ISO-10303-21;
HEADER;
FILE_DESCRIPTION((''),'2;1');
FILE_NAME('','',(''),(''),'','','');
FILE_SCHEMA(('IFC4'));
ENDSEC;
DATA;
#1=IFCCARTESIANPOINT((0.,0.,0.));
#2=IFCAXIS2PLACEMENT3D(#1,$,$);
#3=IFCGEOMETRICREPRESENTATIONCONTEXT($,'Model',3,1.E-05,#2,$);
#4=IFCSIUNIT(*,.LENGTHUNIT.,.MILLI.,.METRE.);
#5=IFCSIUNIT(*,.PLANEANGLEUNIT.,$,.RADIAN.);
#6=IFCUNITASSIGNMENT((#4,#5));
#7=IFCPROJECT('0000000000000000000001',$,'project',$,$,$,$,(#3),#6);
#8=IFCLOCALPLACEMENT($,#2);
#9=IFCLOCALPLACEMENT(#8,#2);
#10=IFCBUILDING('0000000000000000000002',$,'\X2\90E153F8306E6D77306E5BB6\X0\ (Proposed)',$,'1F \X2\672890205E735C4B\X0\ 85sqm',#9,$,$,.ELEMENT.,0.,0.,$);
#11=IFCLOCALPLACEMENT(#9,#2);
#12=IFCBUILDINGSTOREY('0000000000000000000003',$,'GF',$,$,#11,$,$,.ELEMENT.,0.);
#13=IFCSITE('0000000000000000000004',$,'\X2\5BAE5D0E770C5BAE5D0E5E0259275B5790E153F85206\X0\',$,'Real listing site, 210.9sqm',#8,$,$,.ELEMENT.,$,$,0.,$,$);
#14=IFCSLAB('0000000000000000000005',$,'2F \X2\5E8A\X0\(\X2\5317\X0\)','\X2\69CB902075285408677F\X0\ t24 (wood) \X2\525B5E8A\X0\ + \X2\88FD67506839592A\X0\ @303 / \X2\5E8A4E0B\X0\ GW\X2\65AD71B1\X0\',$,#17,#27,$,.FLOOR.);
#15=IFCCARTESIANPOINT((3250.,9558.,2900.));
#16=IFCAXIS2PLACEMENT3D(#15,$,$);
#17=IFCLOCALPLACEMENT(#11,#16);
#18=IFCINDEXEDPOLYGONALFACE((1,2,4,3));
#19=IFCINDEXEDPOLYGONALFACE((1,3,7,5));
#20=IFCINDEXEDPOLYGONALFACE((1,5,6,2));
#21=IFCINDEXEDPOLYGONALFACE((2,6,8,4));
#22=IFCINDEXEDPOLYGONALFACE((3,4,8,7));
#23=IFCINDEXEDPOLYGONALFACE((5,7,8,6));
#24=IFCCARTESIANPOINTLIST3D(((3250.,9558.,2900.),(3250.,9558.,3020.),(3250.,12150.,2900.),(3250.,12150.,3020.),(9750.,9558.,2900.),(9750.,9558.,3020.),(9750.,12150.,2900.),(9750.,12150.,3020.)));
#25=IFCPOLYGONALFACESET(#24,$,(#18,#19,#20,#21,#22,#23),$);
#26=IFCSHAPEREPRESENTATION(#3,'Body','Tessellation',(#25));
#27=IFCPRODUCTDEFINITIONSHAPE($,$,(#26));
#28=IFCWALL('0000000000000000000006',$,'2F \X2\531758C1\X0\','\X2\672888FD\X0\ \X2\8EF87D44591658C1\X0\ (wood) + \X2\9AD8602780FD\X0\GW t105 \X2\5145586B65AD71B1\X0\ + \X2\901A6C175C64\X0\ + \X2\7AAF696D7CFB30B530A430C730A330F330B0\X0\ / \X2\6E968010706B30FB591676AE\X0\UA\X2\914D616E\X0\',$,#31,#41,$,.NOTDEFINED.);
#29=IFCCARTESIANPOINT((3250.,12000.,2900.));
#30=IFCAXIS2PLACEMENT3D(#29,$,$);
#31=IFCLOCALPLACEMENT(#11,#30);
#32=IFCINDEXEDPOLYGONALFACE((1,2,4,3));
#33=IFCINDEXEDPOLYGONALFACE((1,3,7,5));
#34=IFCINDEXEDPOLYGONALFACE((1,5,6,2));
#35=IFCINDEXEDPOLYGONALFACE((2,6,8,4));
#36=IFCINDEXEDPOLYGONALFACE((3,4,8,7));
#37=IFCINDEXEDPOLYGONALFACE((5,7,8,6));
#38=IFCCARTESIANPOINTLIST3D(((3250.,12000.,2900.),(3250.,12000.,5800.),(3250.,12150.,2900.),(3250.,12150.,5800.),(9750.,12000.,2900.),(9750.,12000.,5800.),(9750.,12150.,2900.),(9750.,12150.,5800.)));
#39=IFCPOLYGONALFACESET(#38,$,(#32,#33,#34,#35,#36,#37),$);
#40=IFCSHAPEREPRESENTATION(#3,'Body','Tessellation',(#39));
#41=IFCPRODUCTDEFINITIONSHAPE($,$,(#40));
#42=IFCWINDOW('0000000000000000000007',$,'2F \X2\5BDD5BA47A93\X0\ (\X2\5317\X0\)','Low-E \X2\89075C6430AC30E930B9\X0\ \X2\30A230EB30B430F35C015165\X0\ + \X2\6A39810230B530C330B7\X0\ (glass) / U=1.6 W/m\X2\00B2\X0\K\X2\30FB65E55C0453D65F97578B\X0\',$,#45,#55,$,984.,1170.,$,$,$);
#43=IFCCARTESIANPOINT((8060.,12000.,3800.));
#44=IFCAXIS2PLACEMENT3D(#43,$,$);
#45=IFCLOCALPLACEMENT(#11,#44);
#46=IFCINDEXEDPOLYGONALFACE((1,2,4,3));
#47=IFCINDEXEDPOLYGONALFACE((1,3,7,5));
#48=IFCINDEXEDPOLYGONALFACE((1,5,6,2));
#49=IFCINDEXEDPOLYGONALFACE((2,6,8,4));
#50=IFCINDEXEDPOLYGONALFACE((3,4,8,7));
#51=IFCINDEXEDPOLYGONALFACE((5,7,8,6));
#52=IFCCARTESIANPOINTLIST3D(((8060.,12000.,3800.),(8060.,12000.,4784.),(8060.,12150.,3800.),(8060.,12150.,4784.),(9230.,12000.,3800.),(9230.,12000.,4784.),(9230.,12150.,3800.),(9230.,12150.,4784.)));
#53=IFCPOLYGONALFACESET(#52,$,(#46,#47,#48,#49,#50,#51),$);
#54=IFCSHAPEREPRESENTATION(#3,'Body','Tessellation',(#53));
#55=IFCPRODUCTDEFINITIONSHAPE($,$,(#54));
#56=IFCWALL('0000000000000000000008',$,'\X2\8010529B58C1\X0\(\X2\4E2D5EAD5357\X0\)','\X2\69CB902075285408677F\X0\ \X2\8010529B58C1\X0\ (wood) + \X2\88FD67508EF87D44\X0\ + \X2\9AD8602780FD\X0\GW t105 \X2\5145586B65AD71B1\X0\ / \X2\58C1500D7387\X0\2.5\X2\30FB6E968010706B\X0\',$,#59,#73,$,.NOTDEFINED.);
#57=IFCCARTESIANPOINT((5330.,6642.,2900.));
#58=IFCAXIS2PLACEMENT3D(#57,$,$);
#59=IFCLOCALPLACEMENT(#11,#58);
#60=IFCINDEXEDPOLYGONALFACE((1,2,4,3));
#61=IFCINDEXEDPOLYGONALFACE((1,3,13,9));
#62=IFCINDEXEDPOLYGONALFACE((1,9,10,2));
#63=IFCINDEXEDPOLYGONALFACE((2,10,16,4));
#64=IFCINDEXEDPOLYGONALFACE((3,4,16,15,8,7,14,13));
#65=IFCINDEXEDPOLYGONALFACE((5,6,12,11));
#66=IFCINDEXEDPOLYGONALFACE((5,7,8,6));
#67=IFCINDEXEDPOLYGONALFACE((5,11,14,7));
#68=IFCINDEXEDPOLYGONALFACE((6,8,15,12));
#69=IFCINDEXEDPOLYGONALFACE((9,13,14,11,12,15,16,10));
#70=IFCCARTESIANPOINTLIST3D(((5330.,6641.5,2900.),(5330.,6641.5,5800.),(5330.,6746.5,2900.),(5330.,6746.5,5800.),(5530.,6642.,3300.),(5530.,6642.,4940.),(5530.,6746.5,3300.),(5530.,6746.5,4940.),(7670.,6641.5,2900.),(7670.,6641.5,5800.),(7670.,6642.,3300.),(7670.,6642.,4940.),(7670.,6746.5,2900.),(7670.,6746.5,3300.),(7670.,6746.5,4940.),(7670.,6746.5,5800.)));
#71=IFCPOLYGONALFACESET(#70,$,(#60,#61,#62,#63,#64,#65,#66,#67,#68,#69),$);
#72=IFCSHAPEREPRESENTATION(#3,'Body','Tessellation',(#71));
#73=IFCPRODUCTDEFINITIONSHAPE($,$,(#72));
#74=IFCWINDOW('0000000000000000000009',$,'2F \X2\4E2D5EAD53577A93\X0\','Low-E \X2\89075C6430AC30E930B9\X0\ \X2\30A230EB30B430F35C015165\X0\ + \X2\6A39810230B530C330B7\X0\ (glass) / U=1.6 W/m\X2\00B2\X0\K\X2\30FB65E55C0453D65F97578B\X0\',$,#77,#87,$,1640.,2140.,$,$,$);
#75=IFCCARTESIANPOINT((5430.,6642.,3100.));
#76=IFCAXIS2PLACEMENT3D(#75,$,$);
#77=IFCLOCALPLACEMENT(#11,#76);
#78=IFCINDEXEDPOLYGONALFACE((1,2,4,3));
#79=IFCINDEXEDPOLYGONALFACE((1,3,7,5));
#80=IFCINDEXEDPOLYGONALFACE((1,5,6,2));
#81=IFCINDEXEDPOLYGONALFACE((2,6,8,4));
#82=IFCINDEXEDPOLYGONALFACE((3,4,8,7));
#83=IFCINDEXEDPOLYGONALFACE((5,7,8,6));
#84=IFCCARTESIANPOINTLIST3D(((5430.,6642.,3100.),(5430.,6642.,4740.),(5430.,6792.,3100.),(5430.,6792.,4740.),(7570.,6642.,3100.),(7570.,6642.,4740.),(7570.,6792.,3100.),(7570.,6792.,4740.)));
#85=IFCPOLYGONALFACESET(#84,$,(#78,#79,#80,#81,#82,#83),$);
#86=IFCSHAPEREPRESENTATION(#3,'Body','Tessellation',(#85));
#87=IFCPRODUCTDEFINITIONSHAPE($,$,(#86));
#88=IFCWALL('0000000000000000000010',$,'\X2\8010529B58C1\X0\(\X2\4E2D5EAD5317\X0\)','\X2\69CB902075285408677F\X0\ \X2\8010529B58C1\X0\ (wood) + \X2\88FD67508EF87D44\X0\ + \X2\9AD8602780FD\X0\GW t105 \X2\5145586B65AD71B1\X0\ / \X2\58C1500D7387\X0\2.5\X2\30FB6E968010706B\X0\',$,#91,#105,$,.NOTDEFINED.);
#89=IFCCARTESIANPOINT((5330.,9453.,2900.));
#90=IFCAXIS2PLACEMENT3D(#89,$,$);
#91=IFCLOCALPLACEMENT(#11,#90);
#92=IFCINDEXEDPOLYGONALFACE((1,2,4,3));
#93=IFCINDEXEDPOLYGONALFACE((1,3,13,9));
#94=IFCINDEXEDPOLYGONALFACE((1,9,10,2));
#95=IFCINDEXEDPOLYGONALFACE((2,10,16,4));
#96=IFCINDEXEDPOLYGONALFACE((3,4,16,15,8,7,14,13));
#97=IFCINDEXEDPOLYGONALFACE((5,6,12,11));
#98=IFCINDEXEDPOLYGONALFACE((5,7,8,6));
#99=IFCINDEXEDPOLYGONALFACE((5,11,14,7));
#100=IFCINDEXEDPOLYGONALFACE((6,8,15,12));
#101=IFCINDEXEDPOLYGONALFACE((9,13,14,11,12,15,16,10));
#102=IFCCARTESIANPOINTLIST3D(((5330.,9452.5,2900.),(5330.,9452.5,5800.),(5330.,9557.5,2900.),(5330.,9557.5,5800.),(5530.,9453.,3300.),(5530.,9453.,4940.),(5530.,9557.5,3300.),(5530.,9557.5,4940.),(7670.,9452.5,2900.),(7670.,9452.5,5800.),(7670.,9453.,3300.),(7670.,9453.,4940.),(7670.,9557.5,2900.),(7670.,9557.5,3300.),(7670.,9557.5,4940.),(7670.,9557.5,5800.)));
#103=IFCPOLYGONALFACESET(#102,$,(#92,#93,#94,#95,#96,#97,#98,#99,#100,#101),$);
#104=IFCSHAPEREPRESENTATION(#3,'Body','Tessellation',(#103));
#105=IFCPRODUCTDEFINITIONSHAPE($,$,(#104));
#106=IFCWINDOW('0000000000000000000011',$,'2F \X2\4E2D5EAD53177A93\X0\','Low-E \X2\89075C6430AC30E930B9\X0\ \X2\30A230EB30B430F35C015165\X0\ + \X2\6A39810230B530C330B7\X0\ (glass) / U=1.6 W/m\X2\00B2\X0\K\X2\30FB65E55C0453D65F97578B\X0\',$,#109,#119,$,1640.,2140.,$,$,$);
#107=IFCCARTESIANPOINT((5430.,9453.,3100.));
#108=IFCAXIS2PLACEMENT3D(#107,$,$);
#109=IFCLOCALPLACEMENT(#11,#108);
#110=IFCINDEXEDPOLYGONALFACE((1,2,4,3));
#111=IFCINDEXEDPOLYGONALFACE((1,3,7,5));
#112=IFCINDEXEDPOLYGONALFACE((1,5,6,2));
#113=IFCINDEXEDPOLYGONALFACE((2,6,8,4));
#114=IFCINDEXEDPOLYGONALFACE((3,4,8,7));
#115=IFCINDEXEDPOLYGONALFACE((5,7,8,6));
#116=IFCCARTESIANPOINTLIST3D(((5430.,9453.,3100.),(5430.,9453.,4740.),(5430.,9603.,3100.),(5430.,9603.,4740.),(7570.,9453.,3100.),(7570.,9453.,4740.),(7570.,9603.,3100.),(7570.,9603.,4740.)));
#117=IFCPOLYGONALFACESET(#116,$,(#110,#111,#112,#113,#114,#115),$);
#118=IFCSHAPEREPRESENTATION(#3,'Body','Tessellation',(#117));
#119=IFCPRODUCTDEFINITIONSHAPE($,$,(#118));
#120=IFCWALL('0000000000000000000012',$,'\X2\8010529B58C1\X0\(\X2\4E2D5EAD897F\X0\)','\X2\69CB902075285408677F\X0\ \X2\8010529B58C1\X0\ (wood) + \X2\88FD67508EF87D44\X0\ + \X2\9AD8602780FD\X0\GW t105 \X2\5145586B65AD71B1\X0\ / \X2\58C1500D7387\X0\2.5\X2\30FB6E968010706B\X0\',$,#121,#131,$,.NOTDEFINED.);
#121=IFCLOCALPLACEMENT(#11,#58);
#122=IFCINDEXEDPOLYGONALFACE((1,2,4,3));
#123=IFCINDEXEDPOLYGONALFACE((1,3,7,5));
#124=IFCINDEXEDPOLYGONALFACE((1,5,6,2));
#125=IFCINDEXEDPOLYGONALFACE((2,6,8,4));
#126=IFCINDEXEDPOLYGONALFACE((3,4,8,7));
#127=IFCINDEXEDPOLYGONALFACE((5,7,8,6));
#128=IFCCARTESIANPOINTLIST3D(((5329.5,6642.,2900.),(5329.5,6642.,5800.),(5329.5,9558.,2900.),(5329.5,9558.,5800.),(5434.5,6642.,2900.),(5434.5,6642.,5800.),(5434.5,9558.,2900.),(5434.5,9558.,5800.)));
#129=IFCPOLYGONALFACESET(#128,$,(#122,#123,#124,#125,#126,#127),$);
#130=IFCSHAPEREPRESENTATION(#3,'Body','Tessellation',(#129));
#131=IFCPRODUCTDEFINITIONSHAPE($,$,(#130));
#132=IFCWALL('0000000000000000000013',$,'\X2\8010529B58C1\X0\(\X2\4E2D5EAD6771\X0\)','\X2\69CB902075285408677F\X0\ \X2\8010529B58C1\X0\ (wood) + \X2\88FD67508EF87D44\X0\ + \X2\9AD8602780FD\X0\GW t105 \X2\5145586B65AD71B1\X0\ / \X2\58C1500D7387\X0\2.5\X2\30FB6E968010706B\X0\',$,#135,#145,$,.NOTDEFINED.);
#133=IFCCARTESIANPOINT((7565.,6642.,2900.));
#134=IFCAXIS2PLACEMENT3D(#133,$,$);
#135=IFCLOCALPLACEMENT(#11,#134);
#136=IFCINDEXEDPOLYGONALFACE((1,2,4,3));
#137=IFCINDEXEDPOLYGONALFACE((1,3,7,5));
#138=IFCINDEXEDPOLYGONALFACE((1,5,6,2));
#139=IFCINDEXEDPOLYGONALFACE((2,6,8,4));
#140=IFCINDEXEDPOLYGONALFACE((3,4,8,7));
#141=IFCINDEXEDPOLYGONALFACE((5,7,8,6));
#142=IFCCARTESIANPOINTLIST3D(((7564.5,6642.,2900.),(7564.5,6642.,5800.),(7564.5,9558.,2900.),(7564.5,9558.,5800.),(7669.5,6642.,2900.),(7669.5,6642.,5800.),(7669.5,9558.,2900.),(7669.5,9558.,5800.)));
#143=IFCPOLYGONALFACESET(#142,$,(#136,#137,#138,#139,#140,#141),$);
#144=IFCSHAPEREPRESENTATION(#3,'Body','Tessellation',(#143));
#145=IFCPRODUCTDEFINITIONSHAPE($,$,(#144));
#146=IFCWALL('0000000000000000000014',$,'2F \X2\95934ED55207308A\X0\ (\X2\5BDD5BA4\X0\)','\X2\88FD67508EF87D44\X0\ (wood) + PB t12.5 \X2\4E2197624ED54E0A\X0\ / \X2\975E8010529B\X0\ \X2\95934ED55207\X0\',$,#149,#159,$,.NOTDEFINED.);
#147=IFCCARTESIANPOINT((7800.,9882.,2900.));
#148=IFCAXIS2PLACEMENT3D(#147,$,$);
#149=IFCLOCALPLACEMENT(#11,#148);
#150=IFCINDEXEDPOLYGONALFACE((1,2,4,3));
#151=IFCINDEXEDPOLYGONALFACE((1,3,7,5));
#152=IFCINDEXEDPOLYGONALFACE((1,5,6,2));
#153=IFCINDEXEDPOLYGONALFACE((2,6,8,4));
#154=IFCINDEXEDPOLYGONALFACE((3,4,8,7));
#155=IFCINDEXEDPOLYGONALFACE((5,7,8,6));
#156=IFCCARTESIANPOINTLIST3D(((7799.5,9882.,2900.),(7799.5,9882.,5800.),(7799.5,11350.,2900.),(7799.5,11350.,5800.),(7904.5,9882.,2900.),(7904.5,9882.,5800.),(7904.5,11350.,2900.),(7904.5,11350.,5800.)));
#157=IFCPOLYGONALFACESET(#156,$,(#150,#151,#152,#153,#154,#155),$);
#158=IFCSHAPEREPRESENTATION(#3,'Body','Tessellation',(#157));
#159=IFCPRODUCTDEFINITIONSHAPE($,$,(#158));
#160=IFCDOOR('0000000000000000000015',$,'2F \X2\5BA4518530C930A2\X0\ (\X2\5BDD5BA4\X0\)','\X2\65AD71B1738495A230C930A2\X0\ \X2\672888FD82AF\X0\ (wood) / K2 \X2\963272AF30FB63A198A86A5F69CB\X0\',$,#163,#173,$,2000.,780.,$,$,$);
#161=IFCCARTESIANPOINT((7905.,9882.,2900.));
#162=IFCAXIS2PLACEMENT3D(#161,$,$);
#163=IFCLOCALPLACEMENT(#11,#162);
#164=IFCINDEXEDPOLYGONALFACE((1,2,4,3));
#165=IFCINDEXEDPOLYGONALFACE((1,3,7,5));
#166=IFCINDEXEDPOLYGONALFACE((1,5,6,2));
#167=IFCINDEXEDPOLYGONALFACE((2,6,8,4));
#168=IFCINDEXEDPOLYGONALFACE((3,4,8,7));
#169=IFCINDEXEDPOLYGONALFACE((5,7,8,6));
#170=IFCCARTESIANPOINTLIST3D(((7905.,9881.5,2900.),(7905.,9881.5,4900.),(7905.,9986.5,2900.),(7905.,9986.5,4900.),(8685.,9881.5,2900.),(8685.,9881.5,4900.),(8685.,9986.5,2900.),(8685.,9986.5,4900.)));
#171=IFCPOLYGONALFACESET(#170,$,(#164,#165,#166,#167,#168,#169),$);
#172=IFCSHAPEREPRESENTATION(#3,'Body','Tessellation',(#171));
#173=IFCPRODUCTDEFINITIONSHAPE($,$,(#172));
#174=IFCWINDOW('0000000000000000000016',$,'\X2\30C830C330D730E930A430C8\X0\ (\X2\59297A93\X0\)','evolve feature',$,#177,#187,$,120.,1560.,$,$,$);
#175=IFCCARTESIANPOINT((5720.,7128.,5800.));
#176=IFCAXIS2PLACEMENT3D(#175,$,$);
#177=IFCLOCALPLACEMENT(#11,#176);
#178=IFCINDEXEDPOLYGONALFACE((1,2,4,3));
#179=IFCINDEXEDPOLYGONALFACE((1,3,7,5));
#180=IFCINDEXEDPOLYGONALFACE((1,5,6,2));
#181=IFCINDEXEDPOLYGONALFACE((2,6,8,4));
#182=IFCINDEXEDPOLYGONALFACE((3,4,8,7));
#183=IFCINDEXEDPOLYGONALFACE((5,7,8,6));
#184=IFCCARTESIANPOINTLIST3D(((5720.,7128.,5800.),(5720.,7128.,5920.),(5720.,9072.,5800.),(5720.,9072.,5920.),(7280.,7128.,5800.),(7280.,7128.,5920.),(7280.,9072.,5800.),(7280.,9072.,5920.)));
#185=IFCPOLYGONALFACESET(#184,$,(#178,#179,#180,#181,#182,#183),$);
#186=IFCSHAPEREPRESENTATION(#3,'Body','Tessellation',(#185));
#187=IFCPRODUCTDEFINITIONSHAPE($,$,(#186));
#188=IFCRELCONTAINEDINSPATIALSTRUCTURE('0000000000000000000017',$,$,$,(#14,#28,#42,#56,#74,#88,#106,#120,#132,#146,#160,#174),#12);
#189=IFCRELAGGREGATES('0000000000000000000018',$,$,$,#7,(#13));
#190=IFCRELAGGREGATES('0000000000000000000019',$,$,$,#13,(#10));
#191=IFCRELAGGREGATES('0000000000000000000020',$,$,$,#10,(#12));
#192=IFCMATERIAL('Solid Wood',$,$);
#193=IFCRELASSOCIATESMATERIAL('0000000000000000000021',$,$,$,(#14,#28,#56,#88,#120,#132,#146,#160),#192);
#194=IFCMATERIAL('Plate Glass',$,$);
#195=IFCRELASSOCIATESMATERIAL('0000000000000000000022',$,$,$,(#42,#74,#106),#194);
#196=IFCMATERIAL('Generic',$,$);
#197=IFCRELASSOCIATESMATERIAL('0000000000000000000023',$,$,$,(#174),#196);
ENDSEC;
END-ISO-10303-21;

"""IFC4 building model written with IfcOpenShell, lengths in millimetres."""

from ifc_helpers import new_model, si_unit, frame, frame_2d, origin, place, context, project, spatial, rectangle, extrude, material, element, fill, save


model = new_model("IFC4")

# Units and contexts
model_context = context("Model", 3, precision=1e-05, world=origin())
ifc_project = project(units=[si_unit("LENGTHUNIT", "METRE", prefix="MILLI"), si_unit("PLANEANGLEUNIT", "RADIAN")], contexts=[model_context])

# Site, building, storey
site_placement = place(None, origin())
site = spatial("IfcSite", under=ifc_project, at=site_placement, Name="宮崎県宮崎市大字郡司分", ObjectType="Real listing site, 210.9sqm", CompositionType="ELEMENT", RefElevation=0.0)
building_placement = place(site_placement, origin())
building = spatial("IfcBuilding", under=site, at=building_placement, Name="郡司の海の家 (Proposed)", ObjectType="1F 木造平屋 85sqm", CompositionType="ELEMENT", ElevationOfRefHeight=0.0, ElevationOfTerrain=0.0)
storey_placement = place(building_placement, origin())
storey = spatial("IfcBuildingStorey", under=building, at=storey_placement, Name="GF", CompositionType="ELEMENT", Elevation=0.0)

# Slab
ifc_material_1 = material(Name="Solid Wood")
slab_placement = place(storey_placement, frame((3250.0, 9558.0, 2900.0)))
element("IfcSlab", 1, at=slab_placement, inside=storey, material=ifc_material_1, Name="2F 床(北)", Description="構造用合板 t24 (wood) 剛床 + 製材根太 @303 / 床下 GW断熱", PredefinedType="FLOOR", context=model_context, shape_type="SweptSolid", body=[
    extrude(rectangle(XDim=6500.0, YDim=2592.0, at=frame_2d((3250.0, 1296.0))), frame((3250.0, 9558.0, 2900.0)), (0.0, 0.0, 1.0), 120.0),
])

# Walls, openings, windows
wall_1_placement = place(storey_placement, frame((3250.0, 12000.0, 2900.0)))
wall_1 = element("IfcWall", 2, at=wall_1_placement, inside=storey, material=ifc_material_1, Name="2F 北壁", Description="木製 軸組外壁 (wood) + 高性能GW t105 充填断熱 + 通気層 + 窯業系サイディング / 準耐火・外皮UA配慮", PredefinedType="NOTDEFINED", context=model_context, shape_type="SweptSolid", body=[
    extrude(rectangle(XDim=6500.0, YDim=150.0, at=frame_2d((3250.0, 75.0))), frame((3250.0, 12000.0, 2900.0)), (0.0, 0.0, 1.0), 2900.0),
])
opening_1_placement = place(storey_placement, frame((8060.0, 12000.0, 3800.0)))
opening_1 = element("IfcOpeningElement", 3, at=opening_1_placement, cuts=wall_1, PredefinedType="NOTDEFINED", context=model_context, shape_type="SweptSolid", body=[
    extrude(rectangle(XDim=1170.0, YDim=150.0, at=frame_2d((585.0, 75.0))), frame((8060.0, 12000.0, 3800.0)), (0.0, 0.0, 1.0), 984.0),
])
ifc_material_2 = material(Name="Plate Glass")
window_1_placement = place(storey_placement, frame((8060.0, 12000.0, 3800.0)))
window_1 = element("IfcWindow", 4, at=window_1_placement, inside=storey, material=ifc_material_2, Name="2F 寝室窓 (北)", Description="Low-E 複層ガラス アルゴン封入 + 樹脂サッシ (glass) / U=1.6 W/m²K・日射取得型", OverallHeight=984.0, OverallWidth=1170.0, context=model_context, shape_type="SweptSolid", body=[
    extrude(rectangle(XDim=1170.0, YDim=150.0, at=frame_2d((585.0, 75.0))), frame((8060.0, 12000.0, 3800.0)), (0.0, 0.0, 1.0), 984.0),
])
fill(opening_1, window_1)
wall_2_placement = place(storey_placement, frame((5330.0, 6642.0, 2900.0)))
wall_2 = element("IfcWall", 5, at=wall_2_placement, inside=storey, material=ifc_material_1, Name="耐力壁(中庭南)", Description="構造用合板 耐力壁 (wood) + 製材軸組 + 高性能GW t105 充填断熱 / 壁倍率2.5・準耐火", PredefinedType="NOTDEFINED", context=model_context, shape_type="SweptSolid", body=[
    extrude(rectangle(XDim=2340.0, YDim=105.0, at=frame_2d((1170.0, 52.0))), frame((5330.0, 6642.0, 2900.0)), (0.0, 0.0, 1.0), 2900.0),
])
opening_2_placement = place(storey_placement, frame((5430.0, 6642.0, 3100.0)))
opening_2 = element("IfcOpeningElement", 6, at=opening_2_placement, cuts=wall_2, PredefinedType="NOTDEFINED", context=model_context, shape_type="SweptSolid", body=[
    extrude(rectangle(XDim=2140.0, YDim=150.0, at=frame_2d((1070.0, 75.0))), frame((5430.0, 6642.0, 3100.0)), (0.0, 0.0, 1.0), 1640.0),
])
window_2_placement = place(storey_placement, frame((5430.0, 6642.0, 3100.0)))
window_2 = element("IfcWindow", 7, at=window_2_placement, inside=storey, material=ifc_material_2, Name="2F 中庭南窓", Description="Low-E 複層ガラス アルゴン封入 + 樹脂サッシ (glass) / U=1.6 W/m²K・日射取得型", OverallHeight=1640.0, OverallWidth=2140.0, context=model_context, shape_type="SweptSolid", body=[
    extrude(rectangle(XDim=2140.0, YDim=150.0, at=frame_2d((1070.0, 75.0))), frame((5430.0, 6642.0, 3100.0)), (0.0, 0.0, 1.0), 1640.0),
])
fill(opening_2, window_2)
wall_3_placement = place(storey_placement, frame((5330.0, 9453.0, 2900.0)))
wall_3 = element("IfcWall", 8, at=wall_3_placement, inside=storey, material=ifc_material_1, Name="耐力壁(中庭北)", Description="構造用合板 耐力壁 (wood) + 製材軸組 + 高性能GW t105 充填断熱 / 壁倍率2.5・準耐火", PredefinedType="NOTDEFINED", context=model_context, shape_type="SweptSolid", body=[
    extrude(rectangle(XDim=2340.0, YDim=105.0, at=frame_2d((1170.0, 52.0))), frame((5330.0, 9453.0, 2900.0)), (0.0, 0.0, 1.0), 2900.0),
])
opening_3_placement = place(storey_placement, frame((5430.0, 9453.0, 3100.0)))
opening_3 = element("IfcOpeningElement", 9, at=opening_3_placement, cuts=wall_3, PredefinedType="NOTDEFINED", context=model_context, shape_type="SweptSolid", body=[
    extrude(rectangle(XDim=2140.0, YDim=150.0, at=frame_2d((1070.0, 75.0))), frame((5430.0, 9453.0, 3100.0)), (0.0, 0.0, 1.0), 1640.0),
])
window_3_placement = place(storey_placement, frame((5430.0, 9453.0, 3100.0)))
window_3 = element("IfcWindow", 10, at=window_3_placement, inside=storey, material=ifc_material_2, Name="2F 中庭北窓", Description="Low-E 複層ガラス アルゴン封入 + 樹脂サッシ (glass) / U=1.6 W/m²K・日射取得型", OverallHeight=1640.0, OverallWidth=2140.0, context=model_context, shape_type="SweptSolid", body=[
    extrude(rectangle(XDim=2140.0, YDim=150.0, at=frame_2d((1070.0, 75.0))), frame((5430.0, 9453.0, 3100.0)), (0.0, 0.0, 1.0), 1640.0),
])
fill(opening_3, window_3)

# Walls
wall_4_placement = place(storey_placement, frame((5330.0, 6642.0, 2900.0)))
element("IfcWall", 11, at=wall_4_placement, inside=storey, material=ifc_material_1, Name="耐力壁(中庭西)", Description="構造用合板 耐力壁 (wood) + 製材軸組 + 高性能GW t105 充填断熱 / 壁倍率2.5・準耐火", PredefinedType="NOTDEFINED", context=model_context, shape_type="SweptSolid", body=[
    extrude(rectangle(XDim=105.0, YDim=2916.0, at=frame_2d((52.0, 1458.0))), frame((5330.0, 6642.0, 2900.0)), (0.0, 0.0, 1.0), 2900.0),
])
wall_5_placement = place(storey_placement, frame((7565.0, 6642.0, 2900.0)))
element("IfcWall", 12, at=wall_5_placement, inside=storey, material=ifc_material_1, Name="耐力壁(中庭東)", Description="構造用合板 耐力壁 (wood) + 製材軸組 + 高性能GW t105 充填断熱 / 壁倍率2.5・準耐火", PredefinedType="NOTDEFINED", context=model_context, shape_type="SweptSolid", body=[
    extrude(rectangle(XDim=105.0, YDim=2916.0, at=frame_2d((52.0, 1458.0))), frame((7565.0, 6642.0, 2900.0)), (0.0, 0.0, 1.0), 2900.0),
])
wall_6_placement = place(storey_placement, frame((7800.0, 9882.0, 2900.0)))
element("IfcWall", 13, at=wall_6_placement, inside=storey, material=ifc_material_1, Name="2F 間仕切り (寝室)", Description="製材軸組 (wood) + PB t12.5 両面仕上 / 非耐力 間仕切", PredefinedType="NOTDEFINED", context=model_context, shape_type="SweptSolid", body=[
    extrude(rectangle(XDim=105.0, YDim=1468.0, at=frame_2d((52.0, 734.0))), frame((7800.0, 9882.0, 2900.0)), (0.0, 0.0, 1.0), 2900.0),
])

# Door
door_placement = place(storey_placement, frame((7905.0, 9882.0, 2900.0)))
element("IfcDoor", 14, at=door_placement, inside=storey, material=ifc_material_1, Name="2F 室内ドア (寝室)", Description="断熱玄関ドア 木製芯 (wood) / K2 防犯・採風機構", OverallHeight=2000.0, OverallWidth=780.0, context=model_context, shape_type="SweptSolid", body=[
    extrude(rectangle(XDim=780.0, YDim=105.0, at=frame_2d((390.0, 52.0))), frame((7905.0, 9882.0, 2900.0)), (0.0, 0.0, 1.0), 2000.0),
])

# Window
ifc_material_3 = material(Name="Generic")
window_4_placement = place(storey_placement, frame((5720.0, 7128.0, 5800.0)))
element("IfcWindow", 15, at=window_4_placement, inside=storey, material=ifc_material_3, Name="トップライト (天窓)", Description="evolve feature", OverallHeight=120.0, OverallWidth=1560.0, context=model_context, shape_type="SweptSolid", body=[
    extrude(rectangle(XDim=1560.0, YDim=1944.0, at=frame_2d((780.0, 972.0))), frame((5720.0, 7128.0, 5800.0)), (0.0, 0.0, 1.0), 120.0),
])

save(model, "model.ifc")
